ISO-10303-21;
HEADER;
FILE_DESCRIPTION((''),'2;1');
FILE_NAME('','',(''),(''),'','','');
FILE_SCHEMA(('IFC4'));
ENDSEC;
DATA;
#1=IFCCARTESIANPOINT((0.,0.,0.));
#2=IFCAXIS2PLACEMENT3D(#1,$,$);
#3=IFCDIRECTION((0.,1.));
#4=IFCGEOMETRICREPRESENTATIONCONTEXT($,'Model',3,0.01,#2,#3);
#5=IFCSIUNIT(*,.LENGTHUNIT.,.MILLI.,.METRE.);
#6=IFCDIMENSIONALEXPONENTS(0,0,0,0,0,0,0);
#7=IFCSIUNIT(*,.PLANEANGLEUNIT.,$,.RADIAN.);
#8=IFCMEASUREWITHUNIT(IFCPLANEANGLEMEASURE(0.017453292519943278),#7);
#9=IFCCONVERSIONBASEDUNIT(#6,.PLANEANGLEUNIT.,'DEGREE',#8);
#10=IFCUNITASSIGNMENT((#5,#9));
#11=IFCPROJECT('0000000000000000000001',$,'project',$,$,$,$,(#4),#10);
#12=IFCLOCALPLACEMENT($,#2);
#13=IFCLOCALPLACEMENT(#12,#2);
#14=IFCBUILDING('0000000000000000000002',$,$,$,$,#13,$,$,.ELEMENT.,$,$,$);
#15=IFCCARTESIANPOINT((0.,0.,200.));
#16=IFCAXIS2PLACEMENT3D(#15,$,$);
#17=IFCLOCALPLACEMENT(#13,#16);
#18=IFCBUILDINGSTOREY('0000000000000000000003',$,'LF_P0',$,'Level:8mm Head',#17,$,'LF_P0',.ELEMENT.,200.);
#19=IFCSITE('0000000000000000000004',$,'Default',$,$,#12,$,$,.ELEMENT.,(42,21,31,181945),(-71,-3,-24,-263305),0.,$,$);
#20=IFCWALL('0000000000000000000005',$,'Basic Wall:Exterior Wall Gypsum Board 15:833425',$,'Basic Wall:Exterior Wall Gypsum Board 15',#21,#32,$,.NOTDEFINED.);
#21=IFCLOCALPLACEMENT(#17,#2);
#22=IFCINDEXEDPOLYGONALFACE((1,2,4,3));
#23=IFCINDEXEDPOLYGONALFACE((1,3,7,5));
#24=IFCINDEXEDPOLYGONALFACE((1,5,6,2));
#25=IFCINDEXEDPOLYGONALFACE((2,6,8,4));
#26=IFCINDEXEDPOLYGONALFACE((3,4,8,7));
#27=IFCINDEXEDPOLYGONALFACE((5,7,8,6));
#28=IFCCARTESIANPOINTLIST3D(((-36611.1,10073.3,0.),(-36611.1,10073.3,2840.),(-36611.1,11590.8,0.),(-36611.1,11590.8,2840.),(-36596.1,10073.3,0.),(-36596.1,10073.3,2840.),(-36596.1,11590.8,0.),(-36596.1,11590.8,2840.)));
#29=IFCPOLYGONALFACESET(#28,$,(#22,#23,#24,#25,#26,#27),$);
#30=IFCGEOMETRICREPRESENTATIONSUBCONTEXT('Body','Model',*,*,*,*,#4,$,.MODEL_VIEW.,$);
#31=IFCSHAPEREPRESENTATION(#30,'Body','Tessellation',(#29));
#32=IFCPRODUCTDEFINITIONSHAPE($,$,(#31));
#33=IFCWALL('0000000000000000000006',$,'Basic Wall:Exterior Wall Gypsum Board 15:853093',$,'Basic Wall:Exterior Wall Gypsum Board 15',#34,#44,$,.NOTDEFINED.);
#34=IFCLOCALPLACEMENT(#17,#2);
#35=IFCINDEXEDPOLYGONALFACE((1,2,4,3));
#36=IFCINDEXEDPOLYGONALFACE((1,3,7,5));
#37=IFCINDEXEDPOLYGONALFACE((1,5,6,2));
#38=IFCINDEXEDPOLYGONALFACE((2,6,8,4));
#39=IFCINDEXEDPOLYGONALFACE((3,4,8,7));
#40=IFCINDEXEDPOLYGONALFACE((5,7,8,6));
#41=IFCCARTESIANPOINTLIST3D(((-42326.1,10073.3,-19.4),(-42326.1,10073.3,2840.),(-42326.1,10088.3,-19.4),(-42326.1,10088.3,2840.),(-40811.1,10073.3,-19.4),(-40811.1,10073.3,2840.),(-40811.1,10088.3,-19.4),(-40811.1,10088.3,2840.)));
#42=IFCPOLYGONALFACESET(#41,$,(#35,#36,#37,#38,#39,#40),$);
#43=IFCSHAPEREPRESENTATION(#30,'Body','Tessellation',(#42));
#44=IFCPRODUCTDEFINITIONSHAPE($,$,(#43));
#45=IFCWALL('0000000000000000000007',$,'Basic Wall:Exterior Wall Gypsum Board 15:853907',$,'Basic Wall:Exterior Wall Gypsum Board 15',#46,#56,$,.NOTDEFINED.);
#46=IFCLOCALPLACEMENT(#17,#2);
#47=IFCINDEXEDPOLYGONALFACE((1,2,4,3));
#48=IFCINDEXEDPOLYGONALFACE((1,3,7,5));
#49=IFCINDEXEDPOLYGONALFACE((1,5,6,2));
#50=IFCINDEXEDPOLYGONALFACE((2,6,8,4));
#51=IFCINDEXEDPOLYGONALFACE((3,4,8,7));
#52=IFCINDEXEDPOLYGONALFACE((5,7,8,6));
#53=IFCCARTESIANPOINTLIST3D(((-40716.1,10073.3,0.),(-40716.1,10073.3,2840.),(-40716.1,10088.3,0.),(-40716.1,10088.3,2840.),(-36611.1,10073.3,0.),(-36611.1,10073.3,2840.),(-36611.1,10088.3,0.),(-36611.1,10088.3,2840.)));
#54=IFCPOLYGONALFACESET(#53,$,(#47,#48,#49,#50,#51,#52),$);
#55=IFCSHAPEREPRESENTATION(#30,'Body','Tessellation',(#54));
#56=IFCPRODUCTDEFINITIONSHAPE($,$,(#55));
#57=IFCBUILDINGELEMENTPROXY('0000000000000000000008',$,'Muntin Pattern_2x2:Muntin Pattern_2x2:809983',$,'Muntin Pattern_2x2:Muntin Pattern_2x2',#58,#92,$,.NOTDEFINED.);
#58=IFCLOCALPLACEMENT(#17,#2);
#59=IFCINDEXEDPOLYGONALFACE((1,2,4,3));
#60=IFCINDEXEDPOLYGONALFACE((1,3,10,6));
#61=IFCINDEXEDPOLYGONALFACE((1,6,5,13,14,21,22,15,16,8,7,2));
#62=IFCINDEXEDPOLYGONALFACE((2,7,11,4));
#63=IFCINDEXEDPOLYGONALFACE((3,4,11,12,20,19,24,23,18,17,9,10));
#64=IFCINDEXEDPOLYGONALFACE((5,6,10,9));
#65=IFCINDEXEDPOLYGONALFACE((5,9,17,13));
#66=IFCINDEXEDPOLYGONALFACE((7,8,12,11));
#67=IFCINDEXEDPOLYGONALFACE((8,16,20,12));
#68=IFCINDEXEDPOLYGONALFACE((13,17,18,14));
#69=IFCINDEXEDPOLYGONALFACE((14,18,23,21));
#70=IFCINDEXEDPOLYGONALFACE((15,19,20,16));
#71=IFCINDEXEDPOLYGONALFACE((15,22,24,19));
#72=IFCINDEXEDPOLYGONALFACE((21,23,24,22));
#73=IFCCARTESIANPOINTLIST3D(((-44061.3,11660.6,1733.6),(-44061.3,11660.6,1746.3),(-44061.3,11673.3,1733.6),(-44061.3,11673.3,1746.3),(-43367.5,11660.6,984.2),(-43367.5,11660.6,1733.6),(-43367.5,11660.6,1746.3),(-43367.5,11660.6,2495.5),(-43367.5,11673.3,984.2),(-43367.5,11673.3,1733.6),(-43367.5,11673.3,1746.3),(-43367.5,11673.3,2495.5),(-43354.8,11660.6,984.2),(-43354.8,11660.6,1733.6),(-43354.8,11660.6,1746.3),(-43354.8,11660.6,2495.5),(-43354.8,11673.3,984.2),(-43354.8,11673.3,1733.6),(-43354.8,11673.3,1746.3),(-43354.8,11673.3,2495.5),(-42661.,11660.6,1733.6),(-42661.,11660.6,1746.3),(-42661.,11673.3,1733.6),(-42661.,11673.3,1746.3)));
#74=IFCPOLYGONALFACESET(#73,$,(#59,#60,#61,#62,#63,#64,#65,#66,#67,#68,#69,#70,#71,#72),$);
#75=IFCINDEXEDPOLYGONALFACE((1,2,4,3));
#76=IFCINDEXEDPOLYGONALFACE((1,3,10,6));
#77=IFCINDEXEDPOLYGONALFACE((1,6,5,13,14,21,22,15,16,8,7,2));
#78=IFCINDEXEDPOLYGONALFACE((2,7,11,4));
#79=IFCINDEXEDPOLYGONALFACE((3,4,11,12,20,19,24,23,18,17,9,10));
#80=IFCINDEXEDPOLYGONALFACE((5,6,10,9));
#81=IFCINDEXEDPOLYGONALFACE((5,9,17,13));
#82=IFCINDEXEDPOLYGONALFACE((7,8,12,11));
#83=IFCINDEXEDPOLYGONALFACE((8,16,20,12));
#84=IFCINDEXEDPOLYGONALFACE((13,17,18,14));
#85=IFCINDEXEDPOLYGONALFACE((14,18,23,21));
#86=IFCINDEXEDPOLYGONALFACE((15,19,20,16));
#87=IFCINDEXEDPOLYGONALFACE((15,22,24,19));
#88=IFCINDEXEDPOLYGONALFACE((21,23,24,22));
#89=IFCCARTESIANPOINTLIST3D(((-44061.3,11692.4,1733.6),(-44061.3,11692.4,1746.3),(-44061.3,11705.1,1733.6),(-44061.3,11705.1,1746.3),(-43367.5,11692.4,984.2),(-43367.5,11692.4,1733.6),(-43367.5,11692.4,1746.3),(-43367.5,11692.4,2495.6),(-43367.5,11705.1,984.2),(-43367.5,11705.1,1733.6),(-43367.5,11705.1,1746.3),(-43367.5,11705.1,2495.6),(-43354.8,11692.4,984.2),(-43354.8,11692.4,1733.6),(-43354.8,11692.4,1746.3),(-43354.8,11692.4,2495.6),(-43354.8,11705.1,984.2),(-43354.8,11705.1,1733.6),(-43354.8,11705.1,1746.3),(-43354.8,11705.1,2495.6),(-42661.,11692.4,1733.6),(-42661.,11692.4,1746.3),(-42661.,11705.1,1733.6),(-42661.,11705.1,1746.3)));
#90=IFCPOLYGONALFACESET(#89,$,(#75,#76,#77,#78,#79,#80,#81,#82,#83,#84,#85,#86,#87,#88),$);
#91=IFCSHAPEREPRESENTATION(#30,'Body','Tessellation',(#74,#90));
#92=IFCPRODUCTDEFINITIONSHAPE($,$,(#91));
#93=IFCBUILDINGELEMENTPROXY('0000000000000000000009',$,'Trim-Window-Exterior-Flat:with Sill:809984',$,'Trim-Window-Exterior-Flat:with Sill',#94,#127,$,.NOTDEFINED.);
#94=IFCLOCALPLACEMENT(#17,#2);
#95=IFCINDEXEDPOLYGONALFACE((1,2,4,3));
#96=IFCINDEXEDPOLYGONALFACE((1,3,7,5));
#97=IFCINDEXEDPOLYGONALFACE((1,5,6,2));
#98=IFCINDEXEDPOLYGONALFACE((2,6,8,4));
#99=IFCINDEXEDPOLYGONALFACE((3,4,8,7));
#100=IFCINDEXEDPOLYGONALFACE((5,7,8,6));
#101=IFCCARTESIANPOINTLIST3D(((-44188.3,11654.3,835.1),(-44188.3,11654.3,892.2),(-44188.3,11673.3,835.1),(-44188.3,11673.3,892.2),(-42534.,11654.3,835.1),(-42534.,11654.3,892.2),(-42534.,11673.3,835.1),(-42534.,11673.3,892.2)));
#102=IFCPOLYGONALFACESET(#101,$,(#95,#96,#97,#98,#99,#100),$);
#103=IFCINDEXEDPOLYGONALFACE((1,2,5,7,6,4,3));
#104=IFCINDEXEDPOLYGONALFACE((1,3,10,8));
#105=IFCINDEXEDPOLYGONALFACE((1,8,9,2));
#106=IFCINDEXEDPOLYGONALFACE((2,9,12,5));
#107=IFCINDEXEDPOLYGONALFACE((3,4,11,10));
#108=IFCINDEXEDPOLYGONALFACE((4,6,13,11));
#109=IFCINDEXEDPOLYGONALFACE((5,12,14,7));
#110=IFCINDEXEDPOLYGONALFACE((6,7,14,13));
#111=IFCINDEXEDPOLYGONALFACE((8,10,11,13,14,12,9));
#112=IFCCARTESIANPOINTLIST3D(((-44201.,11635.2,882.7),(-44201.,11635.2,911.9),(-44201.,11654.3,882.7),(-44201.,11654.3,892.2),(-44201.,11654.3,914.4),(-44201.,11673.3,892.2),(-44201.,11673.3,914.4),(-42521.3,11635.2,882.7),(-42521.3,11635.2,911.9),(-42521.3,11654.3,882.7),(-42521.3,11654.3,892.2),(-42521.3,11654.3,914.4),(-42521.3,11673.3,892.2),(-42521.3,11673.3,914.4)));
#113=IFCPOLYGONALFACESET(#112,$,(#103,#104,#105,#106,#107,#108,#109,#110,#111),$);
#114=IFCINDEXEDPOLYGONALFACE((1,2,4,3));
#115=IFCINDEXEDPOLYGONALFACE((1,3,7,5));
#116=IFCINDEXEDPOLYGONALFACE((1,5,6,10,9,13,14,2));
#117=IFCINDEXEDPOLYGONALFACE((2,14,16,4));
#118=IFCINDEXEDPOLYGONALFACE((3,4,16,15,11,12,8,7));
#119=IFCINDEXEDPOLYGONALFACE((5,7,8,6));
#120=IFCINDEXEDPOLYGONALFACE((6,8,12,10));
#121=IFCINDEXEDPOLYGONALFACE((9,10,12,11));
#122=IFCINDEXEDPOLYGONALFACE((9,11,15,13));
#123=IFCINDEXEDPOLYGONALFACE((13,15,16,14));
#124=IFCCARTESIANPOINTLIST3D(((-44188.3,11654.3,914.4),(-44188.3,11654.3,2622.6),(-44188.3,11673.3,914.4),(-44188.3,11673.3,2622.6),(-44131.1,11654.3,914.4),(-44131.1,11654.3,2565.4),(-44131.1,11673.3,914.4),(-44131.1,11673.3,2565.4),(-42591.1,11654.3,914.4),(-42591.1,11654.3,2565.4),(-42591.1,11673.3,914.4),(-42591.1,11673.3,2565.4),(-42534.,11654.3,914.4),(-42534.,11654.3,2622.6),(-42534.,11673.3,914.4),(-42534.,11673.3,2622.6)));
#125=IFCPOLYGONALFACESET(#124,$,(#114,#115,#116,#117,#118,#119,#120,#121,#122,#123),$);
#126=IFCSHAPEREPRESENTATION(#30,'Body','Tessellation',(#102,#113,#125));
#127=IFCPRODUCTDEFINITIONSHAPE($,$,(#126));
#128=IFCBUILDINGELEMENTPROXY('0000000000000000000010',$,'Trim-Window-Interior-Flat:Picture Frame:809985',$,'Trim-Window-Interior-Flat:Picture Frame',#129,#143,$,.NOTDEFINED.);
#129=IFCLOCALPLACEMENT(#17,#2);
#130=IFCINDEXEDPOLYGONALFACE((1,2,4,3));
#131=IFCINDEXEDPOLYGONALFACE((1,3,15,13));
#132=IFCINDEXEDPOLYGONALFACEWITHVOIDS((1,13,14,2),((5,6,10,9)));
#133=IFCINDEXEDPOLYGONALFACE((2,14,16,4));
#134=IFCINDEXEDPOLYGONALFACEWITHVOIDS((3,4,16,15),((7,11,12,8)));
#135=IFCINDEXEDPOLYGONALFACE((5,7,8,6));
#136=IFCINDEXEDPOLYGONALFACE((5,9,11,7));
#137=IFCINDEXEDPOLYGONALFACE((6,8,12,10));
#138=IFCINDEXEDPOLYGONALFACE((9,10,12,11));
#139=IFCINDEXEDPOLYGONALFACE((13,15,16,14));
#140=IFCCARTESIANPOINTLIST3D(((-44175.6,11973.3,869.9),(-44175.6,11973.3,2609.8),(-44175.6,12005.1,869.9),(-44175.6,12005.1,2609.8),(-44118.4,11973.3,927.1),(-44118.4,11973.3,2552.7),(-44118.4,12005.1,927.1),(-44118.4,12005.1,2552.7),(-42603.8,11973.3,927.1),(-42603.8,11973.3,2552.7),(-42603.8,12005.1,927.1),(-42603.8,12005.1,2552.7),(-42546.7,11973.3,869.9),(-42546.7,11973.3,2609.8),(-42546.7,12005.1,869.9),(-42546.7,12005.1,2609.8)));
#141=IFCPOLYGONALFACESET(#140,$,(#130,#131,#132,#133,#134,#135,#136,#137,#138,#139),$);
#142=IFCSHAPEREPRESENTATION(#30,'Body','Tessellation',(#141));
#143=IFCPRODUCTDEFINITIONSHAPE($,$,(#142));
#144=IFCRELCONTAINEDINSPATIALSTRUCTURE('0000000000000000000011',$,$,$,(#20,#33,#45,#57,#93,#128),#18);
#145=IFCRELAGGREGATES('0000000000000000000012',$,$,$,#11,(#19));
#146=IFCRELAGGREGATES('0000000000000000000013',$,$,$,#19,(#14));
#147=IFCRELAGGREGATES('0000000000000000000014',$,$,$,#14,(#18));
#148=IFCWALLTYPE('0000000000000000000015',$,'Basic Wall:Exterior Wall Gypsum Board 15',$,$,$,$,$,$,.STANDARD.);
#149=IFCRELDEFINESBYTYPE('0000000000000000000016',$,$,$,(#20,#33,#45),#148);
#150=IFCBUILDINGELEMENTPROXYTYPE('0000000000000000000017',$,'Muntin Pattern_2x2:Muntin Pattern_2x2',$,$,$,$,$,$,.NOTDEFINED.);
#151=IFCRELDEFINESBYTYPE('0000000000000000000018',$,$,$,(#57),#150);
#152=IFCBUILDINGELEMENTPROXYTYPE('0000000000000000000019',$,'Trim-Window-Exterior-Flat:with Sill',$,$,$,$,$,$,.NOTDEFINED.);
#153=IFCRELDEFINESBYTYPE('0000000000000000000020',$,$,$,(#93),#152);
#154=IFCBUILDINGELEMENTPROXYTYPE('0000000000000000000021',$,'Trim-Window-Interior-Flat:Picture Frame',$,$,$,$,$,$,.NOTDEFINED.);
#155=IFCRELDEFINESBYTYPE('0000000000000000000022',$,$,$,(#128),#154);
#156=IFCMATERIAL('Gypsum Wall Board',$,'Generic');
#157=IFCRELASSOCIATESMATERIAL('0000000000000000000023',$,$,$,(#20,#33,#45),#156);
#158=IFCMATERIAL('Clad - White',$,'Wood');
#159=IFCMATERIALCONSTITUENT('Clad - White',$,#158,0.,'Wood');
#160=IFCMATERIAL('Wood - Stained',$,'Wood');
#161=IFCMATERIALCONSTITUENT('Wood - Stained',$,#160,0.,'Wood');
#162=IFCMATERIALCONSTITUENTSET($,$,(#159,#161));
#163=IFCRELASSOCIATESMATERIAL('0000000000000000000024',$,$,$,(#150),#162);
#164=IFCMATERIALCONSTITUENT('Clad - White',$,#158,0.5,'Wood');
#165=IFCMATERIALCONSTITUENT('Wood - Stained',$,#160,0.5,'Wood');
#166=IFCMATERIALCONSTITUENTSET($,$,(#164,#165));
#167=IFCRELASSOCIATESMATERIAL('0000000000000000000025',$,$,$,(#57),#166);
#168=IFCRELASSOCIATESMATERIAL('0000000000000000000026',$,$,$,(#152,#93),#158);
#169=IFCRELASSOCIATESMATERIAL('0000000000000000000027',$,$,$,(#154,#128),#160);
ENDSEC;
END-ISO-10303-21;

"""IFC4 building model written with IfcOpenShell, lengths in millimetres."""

from ifc_helpers import new_model, entity, si_unit, converted_unit, direction, frame, origin, place, context, subcontext, project, spatial, indexed_curve, outline, extrude, source, transform, mapped, material, constituent, constituent_set, type_object, type_shapes, element, save


model = new_model("IFC4")

# Units and contexts
model_context = context("Model", 3, precision=0.01, world=origin(), true_north=direction((0.0, 1.0)))
body_context = subcontext(model_context, "Body", "Model", "MODEL_VIEW")
ifc_project = project(units=[si_unit("LENGTHUNIT", "METRE", prefix="MILLI"), converted_unit("PLANEANGLEUNIT", "DEGREE", entity("IfcPlaneAngleMeasure", 0.017453292519943278), si_unit("PLANEANGLEUNIT", "RADIAN"), dimensions=[0, 0, 0, 0, 0, 0, 0])], contexts=[model_context])

# Site, building, storey
site_placement = place(None, origin())
site = spatial("IfcSite", under=ifc_project, at=site_placement, Name="Default", CompositionType="ELEMENT", RefLatitude=(42, 21, 31, 181945), RefLongitude=(-71, -3, -24, -263305), RefElevation=0.0)
building_placement = place(site_placement, origin())
building = spatial("IfcBuilding", under=site, at=building_placement, CompositionType="ELEMENT")
storey_placement = place(building_placement, frame((0.0, 0.0, 200.0)))
storey = spatial("IfcBuildingStorey", under=building, at=storey_placement, Name="LF_P0", ObjectType="Level:8mm Head", LongName="LF_P0", CompositionType="ELEMENT", Elevation=200.0)

# Walls
ifc_material_1 = material(Name="Gypsum Wall Board", Category="Generic")
wall_type_1 = type_object("IfcWallType", Name="Basic Wall:Exterior Wall Gypsum Board 15", PredefinedType="STANDARD")
wall_1_placement = place(storey_placement, frame((-36603.6, 10073.3, 0.0), z_axis=(0.0, 0.0, 1.0), x_axis=(0.0, 1.0, 0.0)))
element("IfcWall", 1, at=wall_1_placement, inside=storey, type_object=wall_type_1, material=ifc_material_1, Name="Basic Wall:Exterior Wall Gypsum Board 15:833425", ObjectType="Basic Wall:Exterior Wall Gypsum Board 15", PredefinedType="NOTDEFINED", context=body_context, shape_type="SweptSolid", body=[
    extrude(outline(indexed_curve([(1517.5, 7.5), (0.0, 7.5), (0.0, -7.5), (1517.5, -7.5), (1517.5, 7.5)], self_intersect=False)), origin(), (0.0, 0.0, 1.0), 2840.0),
])
wall_2_placement = place(storey_placement, frame((-42326.1, 10080.8, -19.4)))
element("IfcWall", 2, at=wall_2_placement, inside=storey, type_object=wall_type_1, material=ifc_material_1, Name="Basic Wall:Exterior Wall Gypsum Board 15:853093", ObjectType="Basic Wall:Exterior Wall Gypsum Board 15", PredefinedType="NOTDEFINED", context=body_context, shape_type="SweptSolid", body=[
    extrude(outline(indexed_curve([(1515.0, 7.5), (0.0, 7.5), (0.0, -7.5), (1515.0, -7.5), (1515.0, 7.5)], self_intersect=False)), origin(), (0.0, 0.0, 1.0), 2859.4),
])
wall_3_placement = place(storey_placement, frame((-40716.1, 10080.8, 0.0)))
element("IfcWall", 3, at=wall_3_placement, inside=storey, type_object=wall_type_1, material=ifc_material_1, Name="Basic Wall:Exterior Wall Gypsum Board 15:853907", ObjectType="Basic Wall:Exterior Wall Gypsum Board 15", PredefinedType="NOTDEFINED", context=body_context, shape_type="SweptSolid", body=[
    extrude(outline(indexed_curve([(4105.0, 7.5), (0.0, 7.5), (0.0, -7.5), (4105.0, -7.5), (4105.0, 7.5)], self_intersect=False)), origin(), (0.0, 0.0, 1.0), 2840.0),
])

# Building element proxies
ifc_material_2 = material(Name="Clad - White", Category="Wood")
ifc_constituent_1 = constituent(ifc_material_2, Name="Clad - White", Category="Wood", fraction=0.5)
ifc_material_3 = material(Name="Wood - Stained", Category="Wood")
ifc_constituent_2 = constituent(ifc_material_3, Name="Wood - Stained", Category="Wood", fraction=0.5)
ifc_constituent_set_1 = constituent_set(constituents=[ifc_constituent_1, ifc_constituent_2])
ifc_constituent_3 = constituent(ifc_material_2, Name="Clad - White", Category="Wood", fraction=0.0)
ifc_constituent_4 = constituent(ifc_material_3, Name="Wood - Stained", Category="Wood", fraction=0.0)
ifc_constituent_set_2 = constituent_set(constituents=[ifc_constituent_3, ifc_constituent_4])
building_element_proxy_type_1 = type_object("IfcBuildingElementProxyType", Name="Muntin Pattern_2x2:Muntin Pattern_2x2", PredefinedType="NOTDEFINED", material=ifc_constituent_set_2)
shared_shape_1 = source(origin(), body_context, "Body", "SweptSolid", [
    extrude(outline(indexed_curve([(6.4, -6.4), (755.6, -6.4), (755.6, 6.3), (6.4, 6.3), (6.4, 700.2), (-6.3, 700.2), (-6.3, 6.3), (-755.7, 6.3), (-755.7, -6.4), (-6.3, -6.4), (-6.3, -700.1), (6.4, -700.1), (6.4, -6.4)], self_intersect=False)), frame((0.0, 9.5, 755.6), z_axis=(0.0, 1.0, 0.0), x_axis=(0.0, 0.0, 1.0)), (0.0, 0.0, 1.0), 12.7),
    extrude(outline(indexed_curve([(6.4, -6.4), (755.7, -6.4), (755.7, 6.3), (6.4, 6.3), (6.4, 700.2), (-6.3, 700.2), (-6.3, 6.3), (-755.7, 6.3), (-755.7, -6.4), (-6.3, -6.4), (-6.3, -700.1), (6.4, -700.1), (6.4, -6.4)], self_intersect=False)), frame((0.0, -22.2, 755.7), z_axis=(0.0, 1.0, 0.0), x_axis=(0.0, 0.0, 1.0)), (0.0, 0.0, 1.0), 12.7),
])
type_shapes(building_element_proxy_type_1, [shared_shape_1])
proxy_1_placement = place(storey_placement, frame((-43361.1, 11682.9, 984.2), z_axis=(0.0, 0.0, 1.0), x_axis=(-1.0, 0.0, 0.0)))
element("IfcBuildingElementProxy", 4, at=proxy_1_placement, inside=storey, type_object=building_element_proxy_type_1, material=ifc_constituent_set_1, Name="Muntin Pattern_2x2:Muntin Pattern_2x2:809983", ObjectType="Muntin Pattern_2x2:Muntin Pattern_2x2", PredefinedType="NOTDEFINED", context=body_context, shape_type="MappedRepresentation", body=[
    mapped(shared_shape_1, transform((0.0, 0.0, 0.0), scale=1.0)),
])
building_element_proxy_type_2 = type_object("IfcBuildingElementProxyType", Name="Trim-Window-Exterior-Flat:with Sill", PredefinedType="NOTDEFINED", material=ifc_material_2)
shared_shape_2 = source(origin(), body_context, "Body", "SweptSolid", [
    extrude(outline(indexed_curve([(-827.1, -28.6), (827.1, -28.6), (827.1, 28.6), (-827.1, 28.6), (-827.1, -28.6)], self_intersect=False)), frame((0.0, -1701.8, 0.0), z_axis=(0.0, 0.0, 1.0), x_axis=(-1.0, 0.0, 0.0)), (0.0, 0.0, 1.0), 19.0),
    extrude(outline(indexed_curve([(-19.0, -16.0), (0.0, -16.0), (0.0, -6.4), (19.0, -6.4), (19.0, 15.8), (0.0, 15.8), (-19.0, 13.3), (-19.0, -16.0)], self_intersect=False)), frame((-839.8, -1666.8, 19.0), z_axis=(1.0, 0.0, 0.0), x_axis=(0.0, 0.0, -1.0)), (0.0, 0.0, 1.0), 1679.7),
    extrude(outline(indexed_curve([(-868.4, -827.1), (839.8, -827.1), (839.8, -770.0), (-811.2, -770.0), (-811.2, 770.0), (839.8, 770.0), (839.8, 827.1), (-868.4, 827.1), (-868.4, -827.1)], self_intersect=False)), frame((0.0, -811.2, 0.0), z_axis=(0.0, 0.0, 1.0), x_axis=(0.0, -1.0, 0.0)), (0.0, 0.0, 1.0), 19.0),
])
type_shapes(building_element_proxy_type_2, [shared_shape_2])
proxy_2_placement = place(storey_placement, frame((-43361.1, 11673.3, 2565.4), z_axis=(0.0, -1.0, 0.0), x_axis=(1.0, 0.0, 0.0)))
element("IfcBuildingElementProxy", 5, at=proxy_2_placement, inside=storey, type_object=building_element_proxy_type_2, material=ifc_material_2, Name="Trim-Window-Exterior-Flat:with Sill:809984", ObjectType="Trim-Window-Exterior-Flat:with Sill", PredefinedType="NOTDEFINED", context=body_context, shape_type="MappedRepresentation", body=[
    mapped(shared_shape_2, transform((0.0, 0.0, 0.0), scale=1.0)),
])
building_element_proxy_type_3 = type_object("IfcBuildingElementProxyType", Name="Trim-Window-Interior-Flat:Picture Frame", PredefinedType="NOTDEFINED", material=ifc_material_3)
shared_shape_3 = source(origin(), body_context, "Body", "SweptSolid", [
    extrude(outline(indexed_curve([(-814.4, -869.9), (814.4, -869.9), (814.4, 869.9), (-814.4, 869.9), (-814.4, -869.9)], self_intersect=False), holes=[indexed_curve([(-757.3, -812.8), (-757.3, 812.8), (757.3, 812.8), (757.3, -812.8), (-757.3, -812.8)], self_intersect=False)]), frame((0.0, -825.5, 0.0), z_axis=(0.0, 0.0, 1.0), x_axis=(-1.0, 0.0, 0.0)), (0.0, 0.0, 1.0), 31.7),
])
type_shapes(building_element_proxy_type_3, [shared_shape_3])
proxy_3_placement = place(storey_placement, frame((-43361.1, 11973.3, 2565.4), z_axis=(0.0, 1.0, 0.0), x_axis=(-1.0, 0.0, 0.0)))
element("IfcBuildingElementProxy", 6, at=proxy_3_placement, inside=storey, type_object=building_element_proxy_type_3, material=ifc_material_3, Name="Trim-Window-Interior-Flat:Picture Frame:809985", ObjectType="Trim-Window-Interior-Flat:Picture Frame", PredefinedType="NOTDEFINED", context=body_context, shape_type="MappedRepresentation", body=[
    mapped(shared_shape_3, transform((0.0, 0.0, 0.0), scale=1.0)),
])

save(model, "model.ifc")
